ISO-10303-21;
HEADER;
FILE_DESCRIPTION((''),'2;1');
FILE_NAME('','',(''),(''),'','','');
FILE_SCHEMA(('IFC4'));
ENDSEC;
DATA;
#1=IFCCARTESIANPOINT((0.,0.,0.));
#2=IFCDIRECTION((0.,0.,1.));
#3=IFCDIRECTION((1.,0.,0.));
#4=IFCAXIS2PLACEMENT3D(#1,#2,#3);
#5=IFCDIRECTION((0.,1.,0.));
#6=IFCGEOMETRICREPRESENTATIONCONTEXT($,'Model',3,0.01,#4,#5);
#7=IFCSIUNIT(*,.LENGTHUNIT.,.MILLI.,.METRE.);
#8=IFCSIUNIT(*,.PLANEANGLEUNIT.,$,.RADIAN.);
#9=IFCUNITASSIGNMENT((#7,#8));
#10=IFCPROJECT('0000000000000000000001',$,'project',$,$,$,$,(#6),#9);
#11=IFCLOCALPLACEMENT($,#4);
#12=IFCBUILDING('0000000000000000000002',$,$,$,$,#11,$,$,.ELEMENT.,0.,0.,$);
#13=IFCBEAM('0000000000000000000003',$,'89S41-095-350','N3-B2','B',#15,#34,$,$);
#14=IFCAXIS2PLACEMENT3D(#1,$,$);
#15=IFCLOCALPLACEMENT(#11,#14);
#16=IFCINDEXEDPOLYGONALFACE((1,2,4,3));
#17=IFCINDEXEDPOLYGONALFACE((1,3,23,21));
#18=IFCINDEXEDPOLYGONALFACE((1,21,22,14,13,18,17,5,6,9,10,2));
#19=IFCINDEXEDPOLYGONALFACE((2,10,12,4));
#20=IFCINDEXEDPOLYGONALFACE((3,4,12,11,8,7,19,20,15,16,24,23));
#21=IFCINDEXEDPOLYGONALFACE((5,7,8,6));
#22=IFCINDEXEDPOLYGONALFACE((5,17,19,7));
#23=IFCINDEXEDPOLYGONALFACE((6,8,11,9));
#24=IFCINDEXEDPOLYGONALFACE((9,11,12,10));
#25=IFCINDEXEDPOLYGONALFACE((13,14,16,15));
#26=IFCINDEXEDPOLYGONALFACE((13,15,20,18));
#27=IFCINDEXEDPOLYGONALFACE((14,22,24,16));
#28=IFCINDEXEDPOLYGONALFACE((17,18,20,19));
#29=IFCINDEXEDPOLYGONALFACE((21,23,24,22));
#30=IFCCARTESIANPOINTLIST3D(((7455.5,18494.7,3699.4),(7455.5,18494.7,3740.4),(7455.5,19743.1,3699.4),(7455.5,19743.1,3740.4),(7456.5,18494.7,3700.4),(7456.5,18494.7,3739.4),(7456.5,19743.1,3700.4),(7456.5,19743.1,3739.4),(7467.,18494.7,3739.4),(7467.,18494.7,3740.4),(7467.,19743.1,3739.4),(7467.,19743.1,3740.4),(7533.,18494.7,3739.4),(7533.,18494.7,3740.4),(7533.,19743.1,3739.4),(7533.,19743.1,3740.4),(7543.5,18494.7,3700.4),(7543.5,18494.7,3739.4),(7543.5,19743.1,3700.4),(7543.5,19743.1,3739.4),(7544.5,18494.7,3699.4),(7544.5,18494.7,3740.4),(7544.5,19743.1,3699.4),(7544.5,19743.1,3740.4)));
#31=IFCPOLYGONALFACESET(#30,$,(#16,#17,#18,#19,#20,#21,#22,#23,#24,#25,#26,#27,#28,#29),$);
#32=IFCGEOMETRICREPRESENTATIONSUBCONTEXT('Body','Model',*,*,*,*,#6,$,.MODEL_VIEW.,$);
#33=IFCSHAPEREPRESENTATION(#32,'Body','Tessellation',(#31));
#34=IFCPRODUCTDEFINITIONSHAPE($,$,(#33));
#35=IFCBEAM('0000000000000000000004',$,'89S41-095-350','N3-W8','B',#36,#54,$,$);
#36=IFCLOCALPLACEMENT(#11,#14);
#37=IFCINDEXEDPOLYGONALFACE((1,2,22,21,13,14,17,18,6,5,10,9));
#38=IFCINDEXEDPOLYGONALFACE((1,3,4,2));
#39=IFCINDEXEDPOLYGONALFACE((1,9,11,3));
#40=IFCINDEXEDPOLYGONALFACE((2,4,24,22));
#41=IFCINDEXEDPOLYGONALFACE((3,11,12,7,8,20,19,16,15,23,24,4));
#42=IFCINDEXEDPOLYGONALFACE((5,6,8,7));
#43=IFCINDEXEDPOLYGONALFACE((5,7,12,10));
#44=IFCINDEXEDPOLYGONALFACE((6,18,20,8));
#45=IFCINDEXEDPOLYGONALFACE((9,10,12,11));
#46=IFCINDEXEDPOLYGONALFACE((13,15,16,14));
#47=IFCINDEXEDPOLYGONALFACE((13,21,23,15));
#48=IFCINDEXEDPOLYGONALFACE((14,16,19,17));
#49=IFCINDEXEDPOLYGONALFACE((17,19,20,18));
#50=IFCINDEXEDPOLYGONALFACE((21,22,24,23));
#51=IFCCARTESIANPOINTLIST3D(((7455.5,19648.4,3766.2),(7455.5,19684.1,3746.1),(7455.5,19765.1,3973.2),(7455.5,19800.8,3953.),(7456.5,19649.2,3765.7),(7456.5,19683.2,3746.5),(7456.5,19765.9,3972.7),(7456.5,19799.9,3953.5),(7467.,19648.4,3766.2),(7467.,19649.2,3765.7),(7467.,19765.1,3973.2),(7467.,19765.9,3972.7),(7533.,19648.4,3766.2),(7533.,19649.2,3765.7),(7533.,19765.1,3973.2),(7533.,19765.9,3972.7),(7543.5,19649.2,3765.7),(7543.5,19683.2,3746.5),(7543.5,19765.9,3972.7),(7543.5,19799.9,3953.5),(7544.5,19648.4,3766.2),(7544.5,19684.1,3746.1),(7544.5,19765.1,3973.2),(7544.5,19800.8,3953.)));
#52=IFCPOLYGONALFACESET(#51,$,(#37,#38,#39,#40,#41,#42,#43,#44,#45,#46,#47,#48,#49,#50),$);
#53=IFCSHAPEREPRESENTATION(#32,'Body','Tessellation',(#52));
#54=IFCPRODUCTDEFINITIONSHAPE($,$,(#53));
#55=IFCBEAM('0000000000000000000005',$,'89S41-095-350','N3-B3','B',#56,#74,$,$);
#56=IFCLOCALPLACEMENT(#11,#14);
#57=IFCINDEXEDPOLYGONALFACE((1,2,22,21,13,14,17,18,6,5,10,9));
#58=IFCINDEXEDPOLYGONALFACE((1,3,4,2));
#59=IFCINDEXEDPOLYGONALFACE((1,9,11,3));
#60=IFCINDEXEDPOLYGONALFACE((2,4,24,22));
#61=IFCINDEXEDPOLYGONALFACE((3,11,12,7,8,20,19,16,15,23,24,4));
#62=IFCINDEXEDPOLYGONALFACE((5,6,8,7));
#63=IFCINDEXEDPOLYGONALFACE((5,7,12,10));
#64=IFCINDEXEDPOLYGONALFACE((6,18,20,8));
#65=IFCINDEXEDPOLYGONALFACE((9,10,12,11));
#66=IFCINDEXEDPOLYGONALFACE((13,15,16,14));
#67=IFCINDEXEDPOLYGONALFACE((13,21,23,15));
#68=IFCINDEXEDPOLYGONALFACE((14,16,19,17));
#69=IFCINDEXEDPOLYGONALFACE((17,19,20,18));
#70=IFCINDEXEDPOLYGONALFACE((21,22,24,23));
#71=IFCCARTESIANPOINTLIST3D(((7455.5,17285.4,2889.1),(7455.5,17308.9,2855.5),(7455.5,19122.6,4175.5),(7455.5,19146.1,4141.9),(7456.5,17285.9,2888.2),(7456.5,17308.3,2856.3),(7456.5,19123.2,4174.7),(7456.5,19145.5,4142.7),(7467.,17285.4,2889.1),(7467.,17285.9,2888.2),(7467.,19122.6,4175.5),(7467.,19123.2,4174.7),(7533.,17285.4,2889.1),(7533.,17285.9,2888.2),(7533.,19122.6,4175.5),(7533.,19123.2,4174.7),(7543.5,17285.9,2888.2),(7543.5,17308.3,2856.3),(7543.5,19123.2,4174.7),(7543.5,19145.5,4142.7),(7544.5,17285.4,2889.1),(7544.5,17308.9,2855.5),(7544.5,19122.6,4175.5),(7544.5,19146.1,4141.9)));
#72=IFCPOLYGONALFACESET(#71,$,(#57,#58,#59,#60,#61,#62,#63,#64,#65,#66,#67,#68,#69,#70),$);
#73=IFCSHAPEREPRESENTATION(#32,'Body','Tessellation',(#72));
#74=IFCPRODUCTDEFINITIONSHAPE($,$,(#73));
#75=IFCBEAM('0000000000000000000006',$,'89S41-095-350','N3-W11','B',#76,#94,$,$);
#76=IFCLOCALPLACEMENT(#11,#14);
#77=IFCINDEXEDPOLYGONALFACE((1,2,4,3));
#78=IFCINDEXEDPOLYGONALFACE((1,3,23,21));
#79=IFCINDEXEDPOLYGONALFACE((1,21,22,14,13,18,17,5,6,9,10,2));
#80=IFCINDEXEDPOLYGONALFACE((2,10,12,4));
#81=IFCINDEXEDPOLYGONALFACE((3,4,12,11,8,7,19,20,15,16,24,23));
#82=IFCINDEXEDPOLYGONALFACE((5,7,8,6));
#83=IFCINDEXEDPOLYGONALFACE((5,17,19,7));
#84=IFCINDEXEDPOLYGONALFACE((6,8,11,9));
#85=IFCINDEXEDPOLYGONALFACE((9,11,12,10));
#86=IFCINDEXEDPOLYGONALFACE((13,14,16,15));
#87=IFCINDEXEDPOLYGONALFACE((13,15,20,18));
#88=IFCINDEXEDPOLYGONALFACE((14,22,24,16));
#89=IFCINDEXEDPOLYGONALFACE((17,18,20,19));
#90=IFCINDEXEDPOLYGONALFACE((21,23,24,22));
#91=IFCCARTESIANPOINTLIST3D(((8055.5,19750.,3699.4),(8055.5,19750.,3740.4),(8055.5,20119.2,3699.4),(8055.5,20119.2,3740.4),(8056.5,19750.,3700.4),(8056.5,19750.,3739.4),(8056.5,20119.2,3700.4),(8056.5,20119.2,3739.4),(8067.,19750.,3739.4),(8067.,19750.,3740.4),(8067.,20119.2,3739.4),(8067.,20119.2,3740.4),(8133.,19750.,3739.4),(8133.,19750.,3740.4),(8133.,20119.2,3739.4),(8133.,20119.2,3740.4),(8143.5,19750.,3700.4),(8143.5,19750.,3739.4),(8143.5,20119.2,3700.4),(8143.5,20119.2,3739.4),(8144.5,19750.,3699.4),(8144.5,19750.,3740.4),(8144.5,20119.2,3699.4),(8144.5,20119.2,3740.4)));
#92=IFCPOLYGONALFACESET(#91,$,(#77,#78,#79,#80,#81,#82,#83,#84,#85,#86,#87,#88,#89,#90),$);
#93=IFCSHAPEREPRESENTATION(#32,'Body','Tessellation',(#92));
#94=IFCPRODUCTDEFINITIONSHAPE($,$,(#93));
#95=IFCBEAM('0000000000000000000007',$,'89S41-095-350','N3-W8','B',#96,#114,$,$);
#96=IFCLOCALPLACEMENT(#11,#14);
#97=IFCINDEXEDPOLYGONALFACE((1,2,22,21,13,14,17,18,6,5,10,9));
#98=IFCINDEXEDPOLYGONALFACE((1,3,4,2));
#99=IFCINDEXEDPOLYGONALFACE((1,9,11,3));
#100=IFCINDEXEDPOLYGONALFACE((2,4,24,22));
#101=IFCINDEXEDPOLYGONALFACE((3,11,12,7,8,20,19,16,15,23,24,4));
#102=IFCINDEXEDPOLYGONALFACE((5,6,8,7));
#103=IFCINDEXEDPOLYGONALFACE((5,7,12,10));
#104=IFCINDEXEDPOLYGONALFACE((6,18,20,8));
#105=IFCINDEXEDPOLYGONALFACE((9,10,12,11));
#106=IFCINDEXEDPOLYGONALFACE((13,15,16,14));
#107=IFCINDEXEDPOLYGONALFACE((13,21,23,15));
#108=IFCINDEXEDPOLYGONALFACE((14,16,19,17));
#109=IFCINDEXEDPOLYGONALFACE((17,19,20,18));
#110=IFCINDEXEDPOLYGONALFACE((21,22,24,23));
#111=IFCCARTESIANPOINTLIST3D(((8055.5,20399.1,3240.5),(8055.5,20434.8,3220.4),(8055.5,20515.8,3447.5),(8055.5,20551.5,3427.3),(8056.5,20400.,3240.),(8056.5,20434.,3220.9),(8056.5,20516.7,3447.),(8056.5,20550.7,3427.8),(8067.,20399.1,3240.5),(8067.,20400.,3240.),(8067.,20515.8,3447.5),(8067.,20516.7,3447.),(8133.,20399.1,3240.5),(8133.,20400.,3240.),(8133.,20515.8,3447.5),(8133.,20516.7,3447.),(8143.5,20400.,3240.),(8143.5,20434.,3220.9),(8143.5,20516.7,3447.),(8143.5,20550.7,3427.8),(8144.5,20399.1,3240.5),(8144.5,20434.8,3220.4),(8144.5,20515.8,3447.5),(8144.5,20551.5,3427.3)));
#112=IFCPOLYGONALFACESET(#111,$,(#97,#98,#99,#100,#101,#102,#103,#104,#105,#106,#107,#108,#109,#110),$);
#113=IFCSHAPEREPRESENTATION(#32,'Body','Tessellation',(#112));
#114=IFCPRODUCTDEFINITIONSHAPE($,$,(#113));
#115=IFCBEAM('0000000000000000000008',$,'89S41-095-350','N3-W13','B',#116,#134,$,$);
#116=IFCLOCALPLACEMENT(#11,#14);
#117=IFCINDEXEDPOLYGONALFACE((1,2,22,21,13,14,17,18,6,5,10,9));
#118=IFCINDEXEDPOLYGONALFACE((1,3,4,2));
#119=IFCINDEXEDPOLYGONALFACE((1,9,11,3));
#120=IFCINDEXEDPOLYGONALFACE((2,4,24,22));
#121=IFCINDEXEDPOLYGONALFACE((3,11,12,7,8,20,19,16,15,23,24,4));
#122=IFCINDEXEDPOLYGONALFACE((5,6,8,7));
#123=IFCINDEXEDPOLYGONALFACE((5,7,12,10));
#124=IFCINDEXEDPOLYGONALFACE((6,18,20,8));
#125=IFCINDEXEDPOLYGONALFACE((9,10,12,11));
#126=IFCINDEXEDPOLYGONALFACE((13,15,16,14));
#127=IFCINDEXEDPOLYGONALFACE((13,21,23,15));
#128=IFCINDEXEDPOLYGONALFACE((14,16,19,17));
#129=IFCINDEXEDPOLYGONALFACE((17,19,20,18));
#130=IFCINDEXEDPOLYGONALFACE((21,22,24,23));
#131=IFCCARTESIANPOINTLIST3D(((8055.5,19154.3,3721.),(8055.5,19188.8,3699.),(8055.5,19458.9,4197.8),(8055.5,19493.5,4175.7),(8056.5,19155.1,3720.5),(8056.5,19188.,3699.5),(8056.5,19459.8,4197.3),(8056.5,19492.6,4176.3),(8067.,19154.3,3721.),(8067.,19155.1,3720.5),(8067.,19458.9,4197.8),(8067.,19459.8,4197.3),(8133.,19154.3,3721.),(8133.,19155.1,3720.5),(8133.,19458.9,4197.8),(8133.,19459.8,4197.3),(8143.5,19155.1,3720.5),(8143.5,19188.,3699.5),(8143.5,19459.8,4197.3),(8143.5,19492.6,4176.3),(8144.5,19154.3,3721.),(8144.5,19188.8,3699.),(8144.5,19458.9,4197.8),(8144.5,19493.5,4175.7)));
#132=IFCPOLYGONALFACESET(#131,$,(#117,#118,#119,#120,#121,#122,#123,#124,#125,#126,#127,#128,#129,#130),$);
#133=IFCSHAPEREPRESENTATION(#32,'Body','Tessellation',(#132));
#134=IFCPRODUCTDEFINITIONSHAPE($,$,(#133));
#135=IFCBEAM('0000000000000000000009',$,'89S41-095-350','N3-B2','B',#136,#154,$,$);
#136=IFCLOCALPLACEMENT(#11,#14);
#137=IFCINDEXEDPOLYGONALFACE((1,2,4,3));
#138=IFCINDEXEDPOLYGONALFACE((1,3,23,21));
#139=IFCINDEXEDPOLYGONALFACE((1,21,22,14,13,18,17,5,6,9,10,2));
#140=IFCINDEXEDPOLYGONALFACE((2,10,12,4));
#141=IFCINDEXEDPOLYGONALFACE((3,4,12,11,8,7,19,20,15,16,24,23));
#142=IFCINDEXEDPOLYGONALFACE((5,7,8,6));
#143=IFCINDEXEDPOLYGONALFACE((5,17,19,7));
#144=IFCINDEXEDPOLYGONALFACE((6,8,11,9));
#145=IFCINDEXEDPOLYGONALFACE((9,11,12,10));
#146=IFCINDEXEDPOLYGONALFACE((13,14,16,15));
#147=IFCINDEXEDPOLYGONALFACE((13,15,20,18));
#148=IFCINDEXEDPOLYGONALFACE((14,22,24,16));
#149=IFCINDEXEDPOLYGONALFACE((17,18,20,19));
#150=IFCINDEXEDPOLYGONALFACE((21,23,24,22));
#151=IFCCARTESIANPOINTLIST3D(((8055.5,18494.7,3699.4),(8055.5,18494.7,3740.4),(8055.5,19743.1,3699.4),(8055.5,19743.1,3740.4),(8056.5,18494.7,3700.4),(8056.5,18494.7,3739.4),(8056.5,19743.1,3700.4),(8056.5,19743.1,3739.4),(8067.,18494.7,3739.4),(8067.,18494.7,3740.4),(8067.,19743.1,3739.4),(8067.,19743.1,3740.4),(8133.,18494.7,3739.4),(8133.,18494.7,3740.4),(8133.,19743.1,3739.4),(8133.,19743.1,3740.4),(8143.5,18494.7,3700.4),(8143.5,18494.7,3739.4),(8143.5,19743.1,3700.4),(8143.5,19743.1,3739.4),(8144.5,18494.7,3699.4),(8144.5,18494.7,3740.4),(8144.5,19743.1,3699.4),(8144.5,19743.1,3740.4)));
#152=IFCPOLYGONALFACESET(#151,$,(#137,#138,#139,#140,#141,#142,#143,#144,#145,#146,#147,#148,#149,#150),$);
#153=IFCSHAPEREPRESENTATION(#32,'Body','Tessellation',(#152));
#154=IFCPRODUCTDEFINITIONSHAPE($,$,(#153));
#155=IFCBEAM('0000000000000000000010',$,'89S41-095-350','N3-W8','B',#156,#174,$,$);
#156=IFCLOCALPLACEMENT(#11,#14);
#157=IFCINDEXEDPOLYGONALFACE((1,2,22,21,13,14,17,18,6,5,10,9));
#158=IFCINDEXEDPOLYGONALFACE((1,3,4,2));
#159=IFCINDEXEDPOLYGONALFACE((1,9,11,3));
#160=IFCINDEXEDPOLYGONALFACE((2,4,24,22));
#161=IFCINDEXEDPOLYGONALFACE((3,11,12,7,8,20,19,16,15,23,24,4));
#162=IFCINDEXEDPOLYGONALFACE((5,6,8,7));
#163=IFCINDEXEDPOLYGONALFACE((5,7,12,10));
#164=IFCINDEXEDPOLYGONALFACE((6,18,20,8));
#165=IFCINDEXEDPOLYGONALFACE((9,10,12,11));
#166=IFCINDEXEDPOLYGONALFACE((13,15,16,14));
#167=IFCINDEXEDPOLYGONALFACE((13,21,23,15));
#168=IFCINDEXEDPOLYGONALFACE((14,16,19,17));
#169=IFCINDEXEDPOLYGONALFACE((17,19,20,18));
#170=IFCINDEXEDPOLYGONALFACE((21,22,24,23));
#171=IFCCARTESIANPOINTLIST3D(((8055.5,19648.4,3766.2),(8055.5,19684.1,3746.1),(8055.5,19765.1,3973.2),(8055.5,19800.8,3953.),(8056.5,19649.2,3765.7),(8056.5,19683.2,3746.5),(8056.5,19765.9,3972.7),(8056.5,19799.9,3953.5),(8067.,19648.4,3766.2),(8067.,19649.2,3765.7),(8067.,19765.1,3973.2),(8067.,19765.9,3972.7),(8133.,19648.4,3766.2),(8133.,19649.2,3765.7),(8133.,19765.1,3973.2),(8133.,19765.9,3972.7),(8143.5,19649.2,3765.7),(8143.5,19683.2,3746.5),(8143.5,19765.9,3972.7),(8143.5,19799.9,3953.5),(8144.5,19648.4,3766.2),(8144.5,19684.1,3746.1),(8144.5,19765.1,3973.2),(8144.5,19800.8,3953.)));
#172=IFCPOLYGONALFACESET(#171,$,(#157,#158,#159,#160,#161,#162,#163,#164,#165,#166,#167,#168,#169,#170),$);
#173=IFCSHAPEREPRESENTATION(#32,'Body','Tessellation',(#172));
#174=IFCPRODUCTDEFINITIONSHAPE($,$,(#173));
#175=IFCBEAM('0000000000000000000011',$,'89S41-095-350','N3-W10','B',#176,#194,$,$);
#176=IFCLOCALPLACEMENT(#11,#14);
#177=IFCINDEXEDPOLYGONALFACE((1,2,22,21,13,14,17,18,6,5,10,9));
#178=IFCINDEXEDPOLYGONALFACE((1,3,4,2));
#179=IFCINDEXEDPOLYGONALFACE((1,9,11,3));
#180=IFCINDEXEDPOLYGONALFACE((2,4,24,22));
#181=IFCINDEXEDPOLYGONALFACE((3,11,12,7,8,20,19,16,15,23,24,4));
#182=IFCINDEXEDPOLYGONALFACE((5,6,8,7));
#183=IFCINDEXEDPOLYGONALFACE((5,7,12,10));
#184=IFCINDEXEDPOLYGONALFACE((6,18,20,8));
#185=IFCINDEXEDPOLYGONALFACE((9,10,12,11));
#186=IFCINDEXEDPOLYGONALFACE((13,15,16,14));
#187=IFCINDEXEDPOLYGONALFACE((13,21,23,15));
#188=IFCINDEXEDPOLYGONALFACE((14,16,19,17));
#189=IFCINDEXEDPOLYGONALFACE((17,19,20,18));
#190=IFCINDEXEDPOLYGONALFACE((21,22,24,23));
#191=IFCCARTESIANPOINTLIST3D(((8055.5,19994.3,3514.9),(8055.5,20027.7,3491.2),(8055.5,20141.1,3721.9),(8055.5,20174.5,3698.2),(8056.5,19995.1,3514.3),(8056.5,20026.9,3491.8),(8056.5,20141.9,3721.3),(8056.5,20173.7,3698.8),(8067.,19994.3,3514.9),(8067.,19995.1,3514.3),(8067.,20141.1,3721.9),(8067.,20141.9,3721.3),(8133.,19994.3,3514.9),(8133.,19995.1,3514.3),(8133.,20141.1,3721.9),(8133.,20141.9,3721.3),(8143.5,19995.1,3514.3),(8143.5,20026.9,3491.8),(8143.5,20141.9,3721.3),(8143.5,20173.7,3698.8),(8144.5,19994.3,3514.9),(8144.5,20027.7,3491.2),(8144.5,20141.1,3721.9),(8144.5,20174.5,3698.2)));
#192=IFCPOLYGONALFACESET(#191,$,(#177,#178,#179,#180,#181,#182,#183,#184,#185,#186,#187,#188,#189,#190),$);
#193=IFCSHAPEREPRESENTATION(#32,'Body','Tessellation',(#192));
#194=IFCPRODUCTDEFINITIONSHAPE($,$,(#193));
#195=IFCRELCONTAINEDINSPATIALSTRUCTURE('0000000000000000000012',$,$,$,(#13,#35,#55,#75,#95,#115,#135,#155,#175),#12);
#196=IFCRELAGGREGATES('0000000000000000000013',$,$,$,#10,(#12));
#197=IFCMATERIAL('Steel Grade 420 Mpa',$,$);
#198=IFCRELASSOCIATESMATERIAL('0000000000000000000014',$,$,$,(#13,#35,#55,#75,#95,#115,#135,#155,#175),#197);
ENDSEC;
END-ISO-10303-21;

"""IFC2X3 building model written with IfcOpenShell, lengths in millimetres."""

from ifc_helpers import new_model, si_unit, direction, frame, origin, origin_with_axes, origin_2d_with_axis, place, context, subcontext, project, spatial, c_section, extrude, source, transform, mapped, material, element, save


model = new_model("IFC2X3")

# Units and contexts
model_context = context("Model", 3, precision=0.01, world=origin_with_axes(), true_north=direction((0.0, 1.0, 0.0)))
body_context = subcontext(model_context, "Body", "Model", "MODEL_VIEW")
ifc_project = project(units=[si_unit("LENGTHUNIT", "METRE", prefix="MILLI"), si_unit("PLANEANGLEUNIT", "RADIAN")], contexts=[model_context])

# Building
building_placement = place(None, origin_with_axes())
building = spatial("IfcBuilding", under=ifc_project, at=building_placement, CompositionType="ELEMENT", ElevationOfRefHeight=0.0, ElevationOfTerrain=0.0)

# Shared definitions
ifc_material = material(Name="Steel Grade 420 Mpa")

# Beams
shared_shape_1 = source(origin(), body_context, "Body", "SweptSolid", [
    extrude(c_section(Depth=89.0, Width=41.0, WallThickness=1.0, Girth=11.5, at=origin_2d_with_axis()), origin_with_axes(), (0.0, 0.0, 1.0), 1248.4),
])
beam_1_placement = place(None, frame((7500.0, 19743.1, 3719.9), z_axis=(0.0, -1.0, 0.0), x_axis=(0.0, 0.0, 1.0)))
element("IfcBeam", 1, at=beam_1_placement, inside=building, material=ifc_material, Name="89S41-095-350", Description="N3-B2", ObjectType="B", context=body_context, shape_type="MappedRepresentation", body=[
    mapped(shared_shape_1, transform((0.0, 0.0, 0.0), scale=1.0)),
])
shared_shape_2 = source(origin(), body_context, "Body", "SweptSolid", [
    extrude(c_section(Depth=89.0, Width=41.0, WallThickness=1.0, Girth=11.5, at=origin_2d_with_axis()), origin_with_axes(), (0.0, 0.0, 1.0), 237.6),
])
beam_2_placement = place(None, frame((7500.0, 19782.9, 3963.1), z_axis=(0.0, -0.491169, -0.871064), x_axis=(0.0, -0.871064, 0.491169)))
element("IfcBeam", 2, at=beam_2_placement, inside=building, material=ifc_material, Name="89S41-095-350", Description="N3-W8", ObjectType="B", context=body_context, shape_type="MappedRepresentation", body=[
    mapped(shared_shape_2, transform((0.0, 0.0, 0.0), scale=1.0)),
])
shared_shape_3 = source(origin(), body_context, "Body", "SweptSolid", [
    extrude(c_section(Depth=89.0, Width=41.0, WallThickness=1.0, Girth=11.5, at=origin_2d_with_axis()), origin_with_axes(), (0.0, 0.0, 1.0), 2242.8),
])
beam_3_placement = place(None, frame((7500.0, 19134.3, 4158.7), z_axis=(0.0, -0.819152, -0.573576), x_axis=(0.0, -0.573576, 0.819152)))
element("IfcBeam", 3, at=beam_3_placement, inside=building, material=ifc_material, Name="89S41-095-350", Description="N3-B3", ObjectType="B", context=body_context, shape_type="MappedRepresentation", body=[
    mapped(shared_shape_3, transform((0.0, 0.0, 0.0), scale=1.0)),
])
shared_shape_4 = source(origin(), body_context, "Body", "SweptSolid", [
    extrude(c_section(Depth=89.0, Width=41.0, WallThickness=1.0, Girth=11.5, at=origin_2d_with_axis()), origin_with_axes(), (0.0, 0.0, 1.0), 369.2),
])
beam_4_placement = place(None, frame((8100.0, 20119.2, 3719.9), z_axis=(0.0, -1.0, 0.0), x_axis=(0.0, 0.0, 1.0)))
element("IfcBeam", 4, at=beam_4_placement, inside=building, material=ifc_material, Name="89S41-095-350", Description="N3-W11", ObjectType="B", context=body_context, shape_type="MappedRepresentation", body=[
    mapped(shared_shape_4, transform((0.0, 0.0, 0.0), scale=1.0)),
])
shared_shape_5 = source(origin(), body_context, "Body", "SweptSolid", [
    extrude(c_section(Depth=89.0, Width=41.0, WallThickness=1.0, Girth=11.5, at=origin_2d_with_axis()), origin_with_axes(), (0.0, 0.0, 1.0), 237.6),
])
beam_5_placement = place(None, frame((8100.0, 20533.7, 3437.4), z_axis=(0.0, -0.491169, -0.871064), x_axis=(0.0, -0.871064, 0.491169)))
element("IfcBeam", 5, at=beam_5_placement, inside=building, material=ifc_material, Name="89S41-095-350", Description="N3-W8", ObjectType="B", context=body_context, shape_type="MappedRepresentation", body=[
    mapped(shared_shape_5, transform((0.0, 0.0, 0.0), scale=1.0)),
])
shared_shape_6 = source(origin(), body_context, "Body", "SweptSolid", [
    extrude(c_section(Depth=89.0, Width=41.0, WallThickness=1.0, Girth=11.5, at=origin_2d_with_axis()), origin_with_axes(), (0.0, 0.0, 1.0), 565.8),
])
beam_6_placement = place(None, frame((8100.0, 19476.2, 4186.8), z_axis=(0.0, -0.538498, -0.842627), x_axis=(0.0, -0.842627, 0.538498)))
element("IfcBeam", 6, at=beam_6_placement, inside=building, material=ifc_material, Name="89S41-095-350", Description="N3-W13", ObjectType="B", context=body_context, shape_type="MappedRepresentation", body=[
    mapped(shared_shape_6, transform((0.0, 0.0, 0.0), scale=1.0)),
])
shared_shape_7 = source(origin(), body_context, "Body", "SweptSolid", [
    extrude(c_section(Depth=89.0, Width=41.0, WallThickness=1.0, Girth=11.5, at=origin_2d_with_axis()), origin_with_axes(), (0.0, 0.0, 1.0), 1248.4),
])
beam_7_placement = place(None, frame((8100.0, 19743.1, 3719.9), z_axis=(0.0, -1.0, 0.0), x_axis=(0.0, 0.0, 1.0)))
element("IfcBeam", 7, at=beam_7_placement, inside=building, material=ifc_material, Name="89S41-095-350", Description="N3-B2", ObjectType="B", context=body_context, shape_type="MappedRepresentation", body=[
    mapped(shared_shape_7, transform((0.0, 0.0, 0.0), scale=1.0)),
])
shared_shape_8 = source(origin(), body_context, "Body", "SweptSolid", [
    extrude(c_section(Depth=89.0, Width=41.0, WallThickness=1.0, Girth=11.5, at=origin_2d_with_axis()), origin_with_axes(), (0.0, 0.0, 1.0), 237.6),
])
beam_8_placement = place(None, frame((8100.0, 19782.9, 3963.1), z_axis=(0.0, -0.491169, -0.871064), x_axis=(0.0, -0.871064, 0.491169)))
element("IfcBeam", 8, at=beam_8_placement, inside=building, material=ifc_material, Name="89S41-095-350", Description="N3-W8", ObjectType="B", context=body_context, shape_type="MappedRepresentation", body=[
    mapped(shared_shape_8, transform((0.0, 0.0, 0.0), scale=1.0)),
])
shared_shape_9 = source(origin(), body_context, "Body", "SweptSolid", [
    extrude(c_section(Depth=89.0, Width=41.0, WallThickness=1.0, Girth=11.5, at=origin_2d_with_axis()), origin_with_axes(), (0.0, 0.0, 1.0), 253.8),
])
beam_9_placement = place(None, frame((8100.0, 20157.8, 3710.0), z_axis=(0.0, -0.578484, -0.815694), x_axis=(0.0, -0.815694, 0.578484)))
element("IfcBeam", 9, at=beam_9_placement, inside=building, material=ifc_material, Name="89S41-095-350", Description="N3-W10", ObjectType="B", context=body_context, shape_type="MappedRepresentation", body=[
    mapped(shared_shape_9, transform((0.0, 0.0, 0.0), scale=1.0)),
])

save(model, "model.ifc")
